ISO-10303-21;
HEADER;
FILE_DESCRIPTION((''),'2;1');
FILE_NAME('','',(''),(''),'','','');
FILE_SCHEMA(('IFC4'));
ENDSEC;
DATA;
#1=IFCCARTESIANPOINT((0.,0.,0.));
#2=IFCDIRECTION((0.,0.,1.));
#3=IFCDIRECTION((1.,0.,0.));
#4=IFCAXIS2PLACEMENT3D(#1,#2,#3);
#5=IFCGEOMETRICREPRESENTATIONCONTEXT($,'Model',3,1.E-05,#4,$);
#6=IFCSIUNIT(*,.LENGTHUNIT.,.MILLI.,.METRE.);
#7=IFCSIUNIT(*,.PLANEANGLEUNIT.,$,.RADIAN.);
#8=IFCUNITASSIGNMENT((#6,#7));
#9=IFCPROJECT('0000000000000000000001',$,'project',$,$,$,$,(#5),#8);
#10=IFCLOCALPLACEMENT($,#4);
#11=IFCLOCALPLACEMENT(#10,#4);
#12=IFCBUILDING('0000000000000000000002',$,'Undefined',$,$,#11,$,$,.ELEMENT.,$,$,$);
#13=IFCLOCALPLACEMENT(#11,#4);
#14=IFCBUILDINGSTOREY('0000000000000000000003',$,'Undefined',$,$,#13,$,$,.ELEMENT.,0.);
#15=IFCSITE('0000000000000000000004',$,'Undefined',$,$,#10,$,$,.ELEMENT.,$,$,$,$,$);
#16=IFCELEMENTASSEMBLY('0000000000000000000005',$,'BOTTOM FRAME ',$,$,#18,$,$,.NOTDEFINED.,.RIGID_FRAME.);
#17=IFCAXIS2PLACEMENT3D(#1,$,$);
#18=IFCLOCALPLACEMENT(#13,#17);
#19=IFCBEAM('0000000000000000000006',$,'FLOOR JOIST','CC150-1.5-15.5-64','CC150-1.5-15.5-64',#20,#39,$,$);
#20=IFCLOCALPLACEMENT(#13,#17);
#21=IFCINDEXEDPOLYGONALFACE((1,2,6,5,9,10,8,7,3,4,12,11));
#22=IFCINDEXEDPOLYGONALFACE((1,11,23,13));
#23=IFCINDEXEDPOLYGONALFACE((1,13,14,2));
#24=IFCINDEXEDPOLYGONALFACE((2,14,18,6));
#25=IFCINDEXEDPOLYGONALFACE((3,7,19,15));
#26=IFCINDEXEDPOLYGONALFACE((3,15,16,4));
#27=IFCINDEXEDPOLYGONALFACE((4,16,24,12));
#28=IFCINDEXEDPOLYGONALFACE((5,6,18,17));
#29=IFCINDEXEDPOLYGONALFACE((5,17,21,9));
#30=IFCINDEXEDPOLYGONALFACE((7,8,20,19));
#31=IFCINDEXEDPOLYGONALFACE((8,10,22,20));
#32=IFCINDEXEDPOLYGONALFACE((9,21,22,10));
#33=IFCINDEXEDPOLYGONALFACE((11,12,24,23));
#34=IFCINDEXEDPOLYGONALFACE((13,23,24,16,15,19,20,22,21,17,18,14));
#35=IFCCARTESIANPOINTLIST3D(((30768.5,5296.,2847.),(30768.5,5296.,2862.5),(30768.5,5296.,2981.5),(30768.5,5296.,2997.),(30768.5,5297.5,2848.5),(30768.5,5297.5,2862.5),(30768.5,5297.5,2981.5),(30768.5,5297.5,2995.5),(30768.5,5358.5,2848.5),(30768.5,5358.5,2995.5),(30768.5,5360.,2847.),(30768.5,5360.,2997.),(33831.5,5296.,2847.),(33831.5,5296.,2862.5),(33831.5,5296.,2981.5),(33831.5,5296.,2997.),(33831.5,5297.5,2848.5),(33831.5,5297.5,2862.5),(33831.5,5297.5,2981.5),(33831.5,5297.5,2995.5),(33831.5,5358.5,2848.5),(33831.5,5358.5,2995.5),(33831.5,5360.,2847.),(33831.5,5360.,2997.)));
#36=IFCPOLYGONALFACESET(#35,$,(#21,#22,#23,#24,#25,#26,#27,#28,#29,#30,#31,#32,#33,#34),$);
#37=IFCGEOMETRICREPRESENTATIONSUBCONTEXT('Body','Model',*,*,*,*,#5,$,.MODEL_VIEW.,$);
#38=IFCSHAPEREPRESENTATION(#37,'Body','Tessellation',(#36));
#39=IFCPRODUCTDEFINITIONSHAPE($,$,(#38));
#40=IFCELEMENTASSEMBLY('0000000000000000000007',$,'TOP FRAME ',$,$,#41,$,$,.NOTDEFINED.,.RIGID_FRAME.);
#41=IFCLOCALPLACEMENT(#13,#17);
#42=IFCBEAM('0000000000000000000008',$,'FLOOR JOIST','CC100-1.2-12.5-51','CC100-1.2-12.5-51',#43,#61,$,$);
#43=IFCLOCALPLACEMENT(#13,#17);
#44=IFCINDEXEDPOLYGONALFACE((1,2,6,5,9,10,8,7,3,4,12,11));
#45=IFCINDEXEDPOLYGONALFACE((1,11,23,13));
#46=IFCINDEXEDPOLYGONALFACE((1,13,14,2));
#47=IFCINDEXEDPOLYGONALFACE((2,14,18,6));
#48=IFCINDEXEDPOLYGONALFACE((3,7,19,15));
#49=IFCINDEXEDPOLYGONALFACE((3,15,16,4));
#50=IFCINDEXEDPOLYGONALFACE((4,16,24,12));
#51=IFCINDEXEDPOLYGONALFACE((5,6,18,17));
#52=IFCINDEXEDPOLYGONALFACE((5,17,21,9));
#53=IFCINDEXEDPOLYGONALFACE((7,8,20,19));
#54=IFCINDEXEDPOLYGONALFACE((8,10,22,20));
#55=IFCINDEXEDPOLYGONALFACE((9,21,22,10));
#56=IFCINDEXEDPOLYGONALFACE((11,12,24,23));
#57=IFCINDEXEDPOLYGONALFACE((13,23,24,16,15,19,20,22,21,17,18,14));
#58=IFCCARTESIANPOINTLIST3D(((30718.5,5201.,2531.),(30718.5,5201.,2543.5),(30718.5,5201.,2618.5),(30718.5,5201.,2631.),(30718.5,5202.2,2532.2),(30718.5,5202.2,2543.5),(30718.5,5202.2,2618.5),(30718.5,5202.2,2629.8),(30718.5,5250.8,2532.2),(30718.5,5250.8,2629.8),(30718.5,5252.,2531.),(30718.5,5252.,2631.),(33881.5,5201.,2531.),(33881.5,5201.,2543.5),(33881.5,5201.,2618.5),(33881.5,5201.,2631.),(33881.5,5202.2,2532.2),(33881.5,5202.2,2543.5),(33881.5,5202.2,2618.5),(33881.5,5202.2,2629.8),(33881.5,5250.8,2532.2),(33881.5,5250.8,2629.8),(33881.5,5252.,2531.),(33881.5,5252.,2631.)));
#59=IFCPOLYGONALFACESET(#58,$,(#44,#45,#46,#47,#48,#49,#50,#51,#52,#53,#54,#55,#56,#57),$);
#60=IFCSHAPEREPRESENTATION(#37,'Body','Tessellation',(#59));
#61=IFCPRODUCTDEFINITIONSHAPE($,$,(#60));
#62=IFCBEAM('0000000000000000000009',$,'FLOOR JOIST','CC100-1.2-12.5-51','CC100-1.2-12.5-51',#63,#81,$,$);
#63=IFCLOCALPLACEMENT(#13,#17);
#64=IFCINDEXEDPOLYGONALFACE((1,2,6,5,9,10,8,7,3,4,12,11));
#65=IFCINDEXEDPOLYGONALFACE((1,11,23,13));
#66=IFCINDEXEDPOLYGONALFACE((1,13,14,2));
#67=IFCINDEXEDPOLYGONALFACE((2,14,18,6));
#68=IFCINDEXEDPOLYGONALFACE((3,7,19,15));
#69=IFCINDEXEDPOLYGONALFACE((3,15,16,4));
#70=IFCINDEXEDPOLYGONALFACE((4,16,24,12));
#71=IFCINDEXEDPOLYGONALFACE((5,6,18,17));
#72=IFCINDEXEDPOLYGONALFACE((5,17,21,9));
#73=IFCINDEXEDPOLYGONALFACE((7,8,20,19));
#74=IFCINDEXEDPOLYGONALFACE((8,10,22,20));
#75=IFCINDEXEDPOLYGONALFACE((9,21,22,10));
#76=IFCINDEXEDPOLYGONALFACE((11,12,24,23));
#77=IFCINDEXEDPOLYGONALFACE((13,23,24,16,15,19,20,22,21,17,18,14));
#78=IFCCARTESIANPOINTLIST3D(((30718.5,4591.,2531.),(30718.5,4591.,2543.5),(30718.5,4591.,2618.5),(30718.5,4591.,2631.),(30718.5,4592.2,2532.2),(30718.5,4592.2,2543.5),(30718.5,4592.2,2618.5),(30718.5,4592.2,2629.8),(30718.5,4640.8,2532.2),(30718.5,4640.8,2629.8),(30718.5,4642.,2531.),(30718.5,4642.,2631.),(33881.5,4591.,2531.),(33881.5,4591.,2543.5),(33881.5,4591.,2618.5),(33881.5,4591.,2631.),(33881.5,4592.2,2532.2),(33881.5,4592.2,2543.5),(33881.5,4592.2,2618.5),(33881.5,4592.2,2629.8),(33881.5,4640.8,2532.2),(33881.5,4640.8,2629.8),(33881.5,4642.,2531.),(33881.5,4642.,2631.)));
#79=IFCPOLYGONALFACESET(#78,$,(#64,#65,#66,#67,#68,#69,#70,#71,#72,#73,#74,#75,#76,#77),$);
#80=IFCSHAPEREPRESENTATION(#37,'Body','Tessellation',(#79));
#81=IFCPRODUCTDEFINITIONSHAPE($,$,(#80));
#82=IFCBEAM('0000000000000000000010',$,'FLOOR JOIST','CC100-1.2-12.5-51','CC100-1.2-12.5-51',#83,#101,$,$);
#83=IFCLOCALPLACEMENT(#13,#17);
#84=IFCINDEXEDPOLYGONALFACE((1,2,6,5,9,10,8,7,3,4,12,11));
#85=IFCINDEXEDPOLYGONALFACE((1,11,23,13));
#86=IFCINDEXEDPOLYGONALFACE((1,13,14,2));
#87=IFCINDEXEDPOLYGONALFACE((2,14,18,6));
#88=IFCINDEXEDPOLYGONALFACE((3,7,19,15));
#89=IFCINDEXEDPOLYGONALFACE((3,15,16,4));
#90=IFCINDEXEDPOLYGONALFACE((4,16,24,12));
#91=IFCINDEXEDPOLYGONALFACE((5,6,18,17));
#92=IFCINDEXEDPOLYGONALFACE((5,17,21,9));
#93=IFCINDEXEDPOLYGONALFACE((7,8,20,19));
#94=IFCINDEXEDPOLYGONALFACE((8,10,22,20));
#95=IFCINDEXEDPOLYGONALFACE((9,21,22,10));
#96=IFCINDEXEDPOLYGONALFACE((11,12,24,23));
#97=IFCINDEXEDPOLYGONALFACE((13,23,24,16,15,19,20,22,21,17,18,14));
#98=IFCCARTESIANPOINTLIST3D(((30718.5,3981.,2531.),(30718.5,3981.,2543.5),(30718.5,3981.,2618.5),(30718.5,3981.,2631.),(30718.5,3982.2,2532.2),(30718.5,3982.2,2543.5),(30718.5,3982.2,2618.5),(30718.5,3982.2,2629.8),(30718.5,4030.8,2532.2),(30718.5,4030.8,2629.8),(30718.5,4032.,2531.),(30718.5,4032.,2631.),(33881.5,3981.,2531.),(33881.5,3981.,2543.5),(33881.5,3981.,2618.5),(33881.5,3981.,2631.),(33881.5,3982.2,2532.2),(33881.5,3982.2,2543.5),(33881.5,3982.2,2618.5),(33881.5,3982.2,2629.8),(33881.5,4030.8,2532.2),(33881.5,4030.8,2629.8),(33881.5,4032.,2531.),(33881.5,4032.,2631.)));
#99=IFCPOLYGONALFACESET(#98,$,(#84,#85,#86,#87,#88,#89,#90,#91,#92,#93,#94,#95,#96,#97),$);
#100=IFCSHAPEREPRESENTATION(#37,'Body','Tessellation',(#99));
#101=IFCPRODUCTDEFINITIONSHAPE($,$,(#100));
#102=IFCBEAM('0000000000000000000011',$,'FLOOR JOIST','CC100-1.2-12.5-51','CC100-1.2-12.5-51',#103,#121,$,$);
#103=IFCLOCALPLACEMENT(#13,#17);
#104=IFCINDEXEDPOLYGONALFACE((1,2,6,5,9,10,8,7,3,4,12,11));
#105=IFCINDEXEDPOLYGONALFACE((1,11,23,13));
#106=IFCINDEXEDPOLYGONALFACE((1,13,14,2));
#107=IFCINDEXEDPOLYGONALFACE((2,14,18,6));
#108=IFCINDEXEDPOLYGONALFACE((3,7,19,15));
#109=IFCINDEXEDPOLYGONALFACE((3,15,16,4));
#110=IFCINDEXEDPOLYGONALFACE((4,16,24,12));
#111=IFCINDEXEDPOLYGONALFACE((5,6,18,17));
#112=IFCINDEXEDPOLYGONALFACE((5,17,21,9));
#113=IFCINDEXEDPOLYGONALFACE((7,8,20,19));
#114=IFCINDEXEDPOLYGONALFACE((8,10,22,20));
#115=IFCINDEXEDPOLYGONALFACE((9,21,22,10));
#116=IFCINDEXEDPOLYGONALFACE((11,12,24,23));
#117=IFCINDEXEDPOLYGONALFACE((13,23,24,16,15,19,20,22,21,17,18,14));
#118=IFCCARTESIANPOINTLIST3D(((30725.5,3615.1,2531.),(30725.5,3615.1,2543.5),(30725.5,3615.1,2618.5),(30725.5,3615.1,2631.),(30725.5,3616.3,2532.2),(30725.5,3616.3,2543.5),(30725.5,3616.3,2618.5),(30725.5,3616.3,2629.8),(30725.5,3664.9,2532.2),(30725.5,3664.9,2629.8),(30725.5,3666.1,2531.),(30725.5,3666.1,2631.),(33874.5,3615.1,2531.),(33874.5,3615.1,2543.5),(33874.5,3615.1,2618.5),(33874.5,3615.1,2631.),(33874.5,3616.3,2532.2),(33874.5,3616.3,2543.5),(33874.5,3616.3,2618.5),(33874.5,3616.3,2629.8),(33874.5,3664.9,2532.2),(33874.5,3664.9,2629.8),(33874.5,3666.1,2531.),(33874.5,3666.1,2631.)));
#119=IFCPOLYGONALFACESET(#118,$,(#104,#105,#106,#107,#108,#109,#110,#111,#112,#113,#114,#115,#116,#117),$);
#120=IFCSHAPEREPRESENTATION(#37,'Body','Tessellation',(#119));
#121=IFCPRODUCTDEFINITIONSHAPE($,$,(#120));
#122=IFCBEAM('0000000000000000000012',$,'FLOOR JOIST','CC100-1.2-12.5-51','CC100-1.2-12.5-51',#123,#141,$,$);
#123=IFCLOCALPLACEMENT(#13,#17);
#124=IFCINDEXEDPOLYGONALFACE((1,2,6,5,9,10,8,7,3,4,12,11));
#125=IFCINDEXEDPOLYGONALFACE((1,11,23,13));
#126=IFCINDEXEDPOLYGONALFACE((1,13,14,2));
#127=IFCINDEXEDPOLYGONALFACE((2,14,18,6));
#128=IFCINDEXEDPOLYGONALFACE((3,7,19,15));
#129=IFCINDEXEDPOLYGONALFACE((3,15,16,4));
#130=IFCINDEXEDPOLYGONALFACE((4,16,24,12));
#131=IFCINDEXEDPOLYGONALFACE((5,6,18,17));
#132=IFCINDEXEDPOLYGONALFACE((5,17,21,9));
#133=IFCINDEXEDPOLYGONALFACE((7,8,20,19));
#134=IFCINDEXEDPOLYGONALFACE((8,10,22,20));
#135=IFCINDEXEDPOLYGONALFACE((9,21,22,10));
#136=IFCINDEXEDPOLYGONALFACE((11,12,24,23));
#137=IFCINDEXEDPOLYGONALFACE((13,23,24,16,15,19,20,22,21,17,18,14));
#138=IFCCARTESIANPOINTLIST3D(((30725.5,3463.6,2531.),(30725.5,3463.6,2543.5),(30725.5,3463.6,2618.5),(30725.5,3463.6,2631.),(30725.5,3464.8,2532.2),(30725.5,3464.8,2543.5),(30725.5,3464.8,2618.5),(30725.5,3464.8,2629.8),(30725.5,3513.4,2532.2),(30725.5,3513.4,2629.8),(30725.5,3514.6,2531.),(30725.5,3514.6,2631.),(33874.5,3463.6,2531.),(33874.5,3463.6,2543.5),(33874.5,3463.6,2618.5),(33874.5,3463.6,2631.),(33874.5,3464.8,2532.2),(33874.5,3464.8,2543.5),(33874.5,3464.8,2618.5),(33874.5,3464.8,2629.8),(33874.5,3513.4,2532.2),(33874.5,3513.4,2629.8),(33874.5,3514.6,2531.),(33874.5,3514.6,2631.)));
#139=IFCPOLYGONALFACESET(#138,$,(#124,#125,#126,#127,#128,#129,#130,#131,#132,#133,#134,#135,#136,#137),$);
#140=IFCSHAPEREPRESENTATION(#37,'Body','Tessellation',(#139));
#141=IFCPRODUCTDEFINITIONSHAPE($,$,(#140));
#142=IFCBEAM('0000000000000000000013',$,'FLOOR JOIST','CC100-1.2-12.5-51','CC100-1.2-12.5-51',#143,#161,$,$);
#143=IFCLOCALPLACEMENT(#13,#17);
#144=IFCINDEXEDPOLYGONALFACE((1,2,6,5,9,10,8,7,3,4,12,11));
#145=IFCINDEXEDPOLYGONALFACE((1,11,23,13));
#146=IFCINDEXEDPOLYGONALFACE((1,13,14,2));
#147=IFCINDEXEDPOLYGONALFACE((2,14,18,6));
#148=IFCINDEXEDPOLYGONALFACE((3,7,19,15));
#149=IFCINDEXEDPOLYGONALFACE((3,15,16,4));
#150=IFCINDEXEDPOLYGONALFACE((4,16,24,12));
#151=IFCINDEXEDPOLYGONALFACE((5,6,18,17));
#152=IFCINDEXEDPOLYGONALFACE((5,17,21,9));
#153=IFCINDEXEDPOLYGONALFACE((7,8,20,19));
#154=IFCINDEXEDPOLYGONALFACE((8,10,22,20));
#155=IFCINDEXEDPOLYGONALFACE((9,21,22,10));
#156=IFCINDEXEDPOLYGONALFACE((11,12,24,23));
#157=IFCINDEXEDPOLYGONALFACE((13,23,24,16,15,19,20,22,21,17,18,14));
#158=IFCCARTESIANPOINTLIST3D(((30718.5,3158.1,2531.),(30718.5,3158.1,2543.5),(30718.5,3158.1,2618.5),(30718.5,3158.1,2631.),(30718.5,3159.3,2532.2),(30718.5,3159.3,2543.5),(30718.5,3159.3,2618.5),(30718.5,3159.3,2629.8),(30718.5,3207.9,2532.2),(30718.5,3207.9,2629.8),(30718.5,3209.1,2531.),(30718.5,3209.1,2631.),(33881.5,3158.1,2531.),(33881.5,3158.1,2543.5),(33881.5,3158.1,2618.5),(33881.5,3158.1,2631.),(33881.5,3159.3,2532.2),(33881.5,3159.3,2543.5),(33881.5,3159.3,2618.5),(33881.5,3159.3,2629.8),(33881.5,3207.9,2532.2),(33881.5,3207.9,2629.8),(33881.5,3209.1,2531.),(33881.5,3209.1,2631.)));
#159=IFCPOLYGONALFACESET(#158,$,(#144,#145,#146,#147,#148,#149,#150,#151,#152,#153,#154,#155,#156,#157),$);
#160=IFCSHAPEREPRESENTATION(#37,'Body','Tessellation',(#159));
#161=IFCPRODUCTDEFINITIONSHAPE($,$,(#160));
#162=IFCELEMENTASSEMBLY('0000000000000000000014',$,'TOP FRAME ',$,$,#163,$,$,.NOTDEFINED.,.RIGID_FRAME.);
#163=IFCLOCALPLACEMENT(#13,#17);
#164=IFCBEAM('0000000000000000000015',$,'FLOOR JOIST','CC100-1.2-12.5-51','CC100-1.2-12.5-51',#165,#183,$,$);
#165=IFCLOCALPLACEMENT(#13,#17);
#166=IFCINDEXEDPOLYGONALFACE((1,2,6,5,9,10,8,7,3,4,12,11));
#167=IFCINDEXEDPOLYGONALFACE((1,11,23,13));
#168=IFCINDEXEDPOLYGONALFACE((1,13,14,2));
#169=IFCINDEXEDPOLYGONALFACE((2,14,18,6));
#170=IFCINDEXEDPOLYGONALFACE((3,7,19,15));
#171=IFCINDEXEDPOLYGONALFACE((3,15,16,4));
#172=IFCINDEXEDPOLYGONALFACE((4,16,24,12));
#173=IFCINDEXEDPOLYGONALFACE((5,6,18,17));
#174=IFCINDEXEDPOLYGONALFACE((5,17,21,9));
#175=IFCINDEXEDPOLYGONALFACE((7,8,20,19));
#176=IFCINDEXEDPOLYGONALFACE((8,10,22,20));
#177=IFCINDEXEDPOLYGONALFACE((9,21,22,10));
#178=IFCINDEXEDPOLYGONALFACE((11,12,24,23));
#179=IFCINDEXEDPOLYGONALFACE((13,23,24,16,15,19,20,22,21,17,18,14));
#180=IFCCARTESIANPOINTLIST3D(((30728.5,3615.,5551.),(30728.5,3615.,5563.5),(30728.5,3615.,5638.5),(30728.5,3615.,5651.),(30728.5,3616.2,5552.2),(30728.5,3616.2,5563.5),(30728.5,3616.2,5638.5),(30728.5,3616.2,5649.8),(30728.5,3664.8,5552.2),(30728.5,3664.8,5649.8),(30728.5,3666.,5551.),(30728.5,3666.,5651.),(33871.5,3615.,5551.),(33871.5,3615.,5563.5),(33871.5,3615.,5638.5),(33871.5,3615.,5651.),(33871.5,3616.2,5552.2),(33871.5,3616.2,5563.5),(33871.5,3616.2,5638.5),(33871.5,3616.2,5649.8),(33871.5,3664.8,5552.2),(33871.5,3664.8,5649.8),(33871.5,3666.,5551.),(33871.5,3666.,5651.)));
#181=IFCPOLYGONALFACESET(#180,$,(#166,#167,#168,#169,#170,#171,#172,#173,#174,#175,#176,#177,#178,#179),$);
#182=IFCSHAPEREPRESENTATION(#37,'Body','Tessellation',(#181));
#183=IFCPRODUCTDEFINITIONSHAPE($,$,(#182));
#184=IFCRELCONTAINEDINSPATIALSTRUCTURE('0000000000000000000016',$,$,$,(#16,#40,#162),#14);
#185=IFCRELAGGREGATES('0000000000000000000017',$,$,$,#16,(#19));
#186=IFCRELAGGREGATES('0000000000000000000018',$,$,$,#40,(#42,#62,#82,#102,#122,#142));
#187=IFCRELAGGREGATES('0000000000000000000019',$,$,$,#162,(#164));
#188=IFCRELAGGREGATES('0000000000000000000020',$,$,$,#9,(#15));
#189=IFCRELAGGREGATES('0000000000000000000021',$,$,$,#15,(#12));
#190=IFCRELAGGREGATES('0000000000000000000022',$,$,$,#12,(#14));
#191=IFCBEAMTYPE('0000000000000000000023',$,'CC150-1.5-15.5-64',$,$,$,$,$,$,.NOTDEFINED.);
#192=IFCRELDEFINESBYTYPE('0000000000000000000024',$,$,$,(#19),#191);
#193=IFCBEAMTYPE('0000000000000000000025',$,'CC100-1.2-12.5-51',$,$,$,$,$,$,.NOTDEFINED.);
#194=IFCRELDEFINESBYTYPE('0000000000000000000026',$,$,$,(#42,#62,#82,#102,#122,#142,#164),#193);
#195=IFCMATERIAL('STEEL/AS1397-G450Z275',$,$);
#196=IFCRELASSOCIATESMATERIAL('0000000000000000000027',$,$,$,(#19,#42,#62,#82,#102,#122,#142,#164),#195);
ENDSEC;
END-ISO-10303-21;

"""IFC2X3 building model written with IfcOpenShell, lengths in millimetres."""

from ifc_helpers import new_model, si_unit, frame, origin_with_axes, origin_2d_with_axis, place, context, subcontext, project, spatial, c_section, extrude, material, type_object, element, aggregate, save


model = new_model("IFC2X3")

# Units and contexts
model_context = context("Model", 3, precision=1e-05, world=origin_with_axes())
body_context = subcontext(model_context, "Body", "Model", "MODEL_VIEW")
ifc_project = project(units=[si_unit("LENGTHUNIT", "METRE", prefix="MILLI"), si_unit("PLANEANGLEUNIT", "RADIAN")], contexts=[model_context])

# Site, building, storey
site_placement = place(None, origin_with_axes())
site = spatial("IfcSite", under=ifc_project, at=site_placement, Name="Undefined", CompositionType="ELEMENT")
building_placement = place(site_placement, origin_with_axes())
building = spatial("IfcBuilding", under=site, at=building_placement, Name="Undefined", CompositionType="ELEMENT")
storey_placement = place(building_placement, origin_with_axes())
storey = spatial("IfcBuildingStorey", under=building, at=storey_placement, Name="Undefined", CompositionType="ELEMENT", Elevation=0.0)

# Element assemblies, beams
assembly_1_placement = place(storey_placement, origin_with_axes())
assembly_1 = element("IfcElementAssembly", 1, at=assembly_1_placement, inside=storey, Name="BOTTOM FRAME ", AssemblyPlace="NOTDEFINED", PredefinedType="RIGID_FRAME")
ifc_material_1 = material(Name="STEEL/AS1397-G450Z275")
beam_type_1 = type_object("IfcBeamType", Name="CC150-1.5-15.5-64", PredefinedType="NOTDEFINED")
beam_1_placement = place(assembly_1_placement, frame((30768.5, 5328.0, 2922.0), z_axis=(0.0, 0.0, 1.0), x_axis=(1.0, 0.0, 0.0)))
beam_1 = element("IfcBeam", 2, at=beam_1_placement, type_object=beam_type_1, material=ifc_material_1, Name="FLOOR JOIST", Description="CC150-1.5-15.5-64", ObjectType="CC150-1.5-15.5-64", context=body_context, shape_type="SweptSolid", body=[
    extrude(c_section(Depth=150.0, Width=64.0, WallThickness=1.5, Girth=15.5, at=origin_2d_with_axis()), frame((3063.0, 0.0, 0.0), z_axis=(-1.0, 0.0, 0.0), x_axis=(0.0, -1.0, 0.0)), (0.0, 0.0, 1.0), 3063.0),
])
aggregate(assembly_1, [beam_1])
assembly_2_placement = place(storey_placement, origin_with_axes())
assembly_2 = element("IfcElementAssembly", 3, at=assembly_2_placement, inside=storey, Name="TOP FRAME ", AssemblyPlace="NOTDEFINED", PredefinedType="RIGID_FRAME")
beam_type_2 = type_object("IfcBeamType", Name="CC100-1.2-12.5-51", PredefinedType="NOTDEFINED")
beam_2_placement = place(assembly_2_placement, frame((30718.5, 5226.5, 2581.0), z_axis=(0.0, 0.0, 1.0), x_axis=(1.0, 0.0, 0.0)))
beam_2 = element("IfcBeam", 4, at=beam_2_placement, type_object=beam_type_2, material=ifc_material_1, Name="FLOOR JOIST", Description="CC100-1.2-12.5-51", ObjectType="CC100-1.2-12.5-51", context=body_context, shape_type="SweptSolid", body=[
    extrude(c_section(Depth=100.0, Width=51.0, WallThickness=1.2, Girth=12.5, at=origin_2d_with_axis()), frame((3163.0, 0.0, 0.0), z_axis=(-1.0, 0.0, 0.0), x_axis=(0.0, -1.0, 0.0)), (0.0, 0.0, 1.0), 3163.0),
])
beam_3_placement = place(assembly_2_placement, frame((30718.5, 4616.5, 2581.0), z_axis=(0.0, 0.0, 1.0), x_axis=(1.0, 0.0, 0.0)))
beam_3 = element("IfcBeam", 5, at=beam_3_placement, type_object=beam_type_2, material=ifc_material_1, Name="FLOOR JOIST", Description="CC100-1.2-12.5-51", ObjectType="CC100-1.2-12.5-51", context=body_context, shape_type="SweptSolid", body=[
    extrude(c_section(Depth=100.0, Width=51.0, WallThickness=1.2, Girth=12.5, at=origin_2d_with_axis()), frame((3163.0, 0.0, 0.0), z_axis=(-1.0, 0.0, 0.0), x_axis=(0.0, -1.0, 0.0)), (0.0, 0.0, 1.0), 3163.0),
])
beam_4_placement = place(assembly_2_placement, frame((30718.5, 4006.5, 2581.0), z_axis=(0.0, 0.0, 1.0), x_axis=(1.0, 0.0, 0.0)))
beam_4 = element("IfcBeam", 6, at=beam_4_placement, type_object=beam_type_2, material=ifc_material_1, Name="FLOOR JOIST", Description="CC100-1.2-12.5-51", ObjectType="CC100-1.2-12.5-51", context=body_context, shape_type="SweptSolid", body=[
    extrude(c_section(Depth=100.0, Width=51.0, WallThickness=1.2, Girth=12.5, at=origin_2d_with_axis()), frame((3163.0, 0.0, 0.0), z_axis=(-1.0, 0.0, 0.0), x_axis=(0.0, -1.0, 0.0)), (0.0, 0.0, 1.0), 3163.0),
])
beam_5_placement = place(assembly_2_placement, frame((30725.5, 3640.6, 2581.0), z_axis=(0.0, 0.0, 1.0), x_axis=(1.0, 0.0, 0.0)))
beam_5 = element("IfcBeam", 7, at=beam_5_placement, type_object=beam_type_2, material=ifc_material_1, Name="FLOOR JOIST", Description="CC100-1.2-12.5-51", ObjectType="CC100-1.2-12.5-51", context=body_context, shape_type="SweptSolid", body=[
    extrude(c_section(Depth=100.0, Width=51.0, WallThickness=1.2, Girth=12.5, at=origin_2d_with_axis()), frame((3149.0, 0.0, 0.0), z_axis=(-1.0, 0.0, 0.0), x_axis=(0.0, -1.0, 0.0)), (0.0, 0.0, 1.0), 3149.0),
])
beam_6_placement = place(assembly_2_placement, frame((30725.5, 3489.1, 2581.0), z_axis=(0.0, 0.0, 1.0), x_axis=(1.0, 0.0, 0.0)))
beam_6 = element("IfcBeam", 8, at=beam_6_placement, type_object=beam_type_2, material=ifc_material_1, Name="FLOOR JOIST", Description="CC100-1.2-12.5-51", ObjectType="CC100-1.2-12.5-51", context=body_context, shape_type="SweptSolid", body=[
    extrude(c_section(Depth=100.0, Width=51.0, WallThickness=1.2, Girth=12.5, at=origin_2d_with_axis()), frame((3149.0, 0.0, 0.0), z_axis=(-1.0, 0.0, 0.0), x_axis=(0.0, -1.0, 0.0)), (0.0, 0.0, 1.0), 3149.0),
])
beam_7_placement = place(assembly_2_placement, frame((30718.5, 3183.6, 2581.0), z_axis=(0.0, 0.0, 1.0), x_axis=(1.0, 0.0, 0.0)))
beam_7 = element("IfcBeam", 9, at=beam_7_placement, type_object=beam_type_2, material=ifc_material_1, Name="FLOOR JOIST", Description="CC100-1.2-12.5-51", ObjectType="CC100-1.2-12.5-51", context=body_context, shape_type="SweptSolid", body=[
    extrude(c_section(Depth=100.0, Width=51.0, WallThickness=1.2, Girth=12.5, at=origin_2d_with_axis()), frame((3163.0, 0.0, 0.0), z_axis=(-1.0, 0.0, 0.0), x_axis=(0.0, -1.0, 0.0)), (0.0, 0.0, 1.0), 3163.0),
])
aggregate(assembly_2, [beam_2, beam_3, beam_4, beam_5, beam_6, beam_7])
assembly_3_placement = place(storey_placement, origin_with_axes())
assembly_3 = element("IfcElementAssembly", 10, at=assembly_3_placement, inside=storey, Name="TOP FRAME ", AssemblyPlace="NOTDEFINED", PredefinedType="RIGID_FRAME")
beam_8_placement = place(assembly_3_placement, frame((30728.5, 3640.5, 5601.0), z_axis=(0.0, 0.0, 1.0), x_axis=(1.0, 0.0, 0.0)))
beam_8 = element("IfcBeam", 11, at=beam_8_placement, type_object=beam_type_2, material=ifc_material_1, Name="FLOOR JOIST", Description="CC100-1.2-12.5-51", ObjectType="CC100-1.2-12.5-51", context=body_context, shape_type="SweptSolid", body=[
    extrude(c_section(Depth=100.0, Width=51.0, WallThickness=1.2, Girth=12.5, at=origin_2d_with_axis()), frame((3143.0, 0.0, 0.0), z_axis=(-1.0, 0.0, 0.0), x_axis=(0.0, -1.0, 0.0)), (0.0, 0.0, 1.0), 3143.0),
])
aggregate(assembly_3, [beam_8])

save(model, "model.ifc")
